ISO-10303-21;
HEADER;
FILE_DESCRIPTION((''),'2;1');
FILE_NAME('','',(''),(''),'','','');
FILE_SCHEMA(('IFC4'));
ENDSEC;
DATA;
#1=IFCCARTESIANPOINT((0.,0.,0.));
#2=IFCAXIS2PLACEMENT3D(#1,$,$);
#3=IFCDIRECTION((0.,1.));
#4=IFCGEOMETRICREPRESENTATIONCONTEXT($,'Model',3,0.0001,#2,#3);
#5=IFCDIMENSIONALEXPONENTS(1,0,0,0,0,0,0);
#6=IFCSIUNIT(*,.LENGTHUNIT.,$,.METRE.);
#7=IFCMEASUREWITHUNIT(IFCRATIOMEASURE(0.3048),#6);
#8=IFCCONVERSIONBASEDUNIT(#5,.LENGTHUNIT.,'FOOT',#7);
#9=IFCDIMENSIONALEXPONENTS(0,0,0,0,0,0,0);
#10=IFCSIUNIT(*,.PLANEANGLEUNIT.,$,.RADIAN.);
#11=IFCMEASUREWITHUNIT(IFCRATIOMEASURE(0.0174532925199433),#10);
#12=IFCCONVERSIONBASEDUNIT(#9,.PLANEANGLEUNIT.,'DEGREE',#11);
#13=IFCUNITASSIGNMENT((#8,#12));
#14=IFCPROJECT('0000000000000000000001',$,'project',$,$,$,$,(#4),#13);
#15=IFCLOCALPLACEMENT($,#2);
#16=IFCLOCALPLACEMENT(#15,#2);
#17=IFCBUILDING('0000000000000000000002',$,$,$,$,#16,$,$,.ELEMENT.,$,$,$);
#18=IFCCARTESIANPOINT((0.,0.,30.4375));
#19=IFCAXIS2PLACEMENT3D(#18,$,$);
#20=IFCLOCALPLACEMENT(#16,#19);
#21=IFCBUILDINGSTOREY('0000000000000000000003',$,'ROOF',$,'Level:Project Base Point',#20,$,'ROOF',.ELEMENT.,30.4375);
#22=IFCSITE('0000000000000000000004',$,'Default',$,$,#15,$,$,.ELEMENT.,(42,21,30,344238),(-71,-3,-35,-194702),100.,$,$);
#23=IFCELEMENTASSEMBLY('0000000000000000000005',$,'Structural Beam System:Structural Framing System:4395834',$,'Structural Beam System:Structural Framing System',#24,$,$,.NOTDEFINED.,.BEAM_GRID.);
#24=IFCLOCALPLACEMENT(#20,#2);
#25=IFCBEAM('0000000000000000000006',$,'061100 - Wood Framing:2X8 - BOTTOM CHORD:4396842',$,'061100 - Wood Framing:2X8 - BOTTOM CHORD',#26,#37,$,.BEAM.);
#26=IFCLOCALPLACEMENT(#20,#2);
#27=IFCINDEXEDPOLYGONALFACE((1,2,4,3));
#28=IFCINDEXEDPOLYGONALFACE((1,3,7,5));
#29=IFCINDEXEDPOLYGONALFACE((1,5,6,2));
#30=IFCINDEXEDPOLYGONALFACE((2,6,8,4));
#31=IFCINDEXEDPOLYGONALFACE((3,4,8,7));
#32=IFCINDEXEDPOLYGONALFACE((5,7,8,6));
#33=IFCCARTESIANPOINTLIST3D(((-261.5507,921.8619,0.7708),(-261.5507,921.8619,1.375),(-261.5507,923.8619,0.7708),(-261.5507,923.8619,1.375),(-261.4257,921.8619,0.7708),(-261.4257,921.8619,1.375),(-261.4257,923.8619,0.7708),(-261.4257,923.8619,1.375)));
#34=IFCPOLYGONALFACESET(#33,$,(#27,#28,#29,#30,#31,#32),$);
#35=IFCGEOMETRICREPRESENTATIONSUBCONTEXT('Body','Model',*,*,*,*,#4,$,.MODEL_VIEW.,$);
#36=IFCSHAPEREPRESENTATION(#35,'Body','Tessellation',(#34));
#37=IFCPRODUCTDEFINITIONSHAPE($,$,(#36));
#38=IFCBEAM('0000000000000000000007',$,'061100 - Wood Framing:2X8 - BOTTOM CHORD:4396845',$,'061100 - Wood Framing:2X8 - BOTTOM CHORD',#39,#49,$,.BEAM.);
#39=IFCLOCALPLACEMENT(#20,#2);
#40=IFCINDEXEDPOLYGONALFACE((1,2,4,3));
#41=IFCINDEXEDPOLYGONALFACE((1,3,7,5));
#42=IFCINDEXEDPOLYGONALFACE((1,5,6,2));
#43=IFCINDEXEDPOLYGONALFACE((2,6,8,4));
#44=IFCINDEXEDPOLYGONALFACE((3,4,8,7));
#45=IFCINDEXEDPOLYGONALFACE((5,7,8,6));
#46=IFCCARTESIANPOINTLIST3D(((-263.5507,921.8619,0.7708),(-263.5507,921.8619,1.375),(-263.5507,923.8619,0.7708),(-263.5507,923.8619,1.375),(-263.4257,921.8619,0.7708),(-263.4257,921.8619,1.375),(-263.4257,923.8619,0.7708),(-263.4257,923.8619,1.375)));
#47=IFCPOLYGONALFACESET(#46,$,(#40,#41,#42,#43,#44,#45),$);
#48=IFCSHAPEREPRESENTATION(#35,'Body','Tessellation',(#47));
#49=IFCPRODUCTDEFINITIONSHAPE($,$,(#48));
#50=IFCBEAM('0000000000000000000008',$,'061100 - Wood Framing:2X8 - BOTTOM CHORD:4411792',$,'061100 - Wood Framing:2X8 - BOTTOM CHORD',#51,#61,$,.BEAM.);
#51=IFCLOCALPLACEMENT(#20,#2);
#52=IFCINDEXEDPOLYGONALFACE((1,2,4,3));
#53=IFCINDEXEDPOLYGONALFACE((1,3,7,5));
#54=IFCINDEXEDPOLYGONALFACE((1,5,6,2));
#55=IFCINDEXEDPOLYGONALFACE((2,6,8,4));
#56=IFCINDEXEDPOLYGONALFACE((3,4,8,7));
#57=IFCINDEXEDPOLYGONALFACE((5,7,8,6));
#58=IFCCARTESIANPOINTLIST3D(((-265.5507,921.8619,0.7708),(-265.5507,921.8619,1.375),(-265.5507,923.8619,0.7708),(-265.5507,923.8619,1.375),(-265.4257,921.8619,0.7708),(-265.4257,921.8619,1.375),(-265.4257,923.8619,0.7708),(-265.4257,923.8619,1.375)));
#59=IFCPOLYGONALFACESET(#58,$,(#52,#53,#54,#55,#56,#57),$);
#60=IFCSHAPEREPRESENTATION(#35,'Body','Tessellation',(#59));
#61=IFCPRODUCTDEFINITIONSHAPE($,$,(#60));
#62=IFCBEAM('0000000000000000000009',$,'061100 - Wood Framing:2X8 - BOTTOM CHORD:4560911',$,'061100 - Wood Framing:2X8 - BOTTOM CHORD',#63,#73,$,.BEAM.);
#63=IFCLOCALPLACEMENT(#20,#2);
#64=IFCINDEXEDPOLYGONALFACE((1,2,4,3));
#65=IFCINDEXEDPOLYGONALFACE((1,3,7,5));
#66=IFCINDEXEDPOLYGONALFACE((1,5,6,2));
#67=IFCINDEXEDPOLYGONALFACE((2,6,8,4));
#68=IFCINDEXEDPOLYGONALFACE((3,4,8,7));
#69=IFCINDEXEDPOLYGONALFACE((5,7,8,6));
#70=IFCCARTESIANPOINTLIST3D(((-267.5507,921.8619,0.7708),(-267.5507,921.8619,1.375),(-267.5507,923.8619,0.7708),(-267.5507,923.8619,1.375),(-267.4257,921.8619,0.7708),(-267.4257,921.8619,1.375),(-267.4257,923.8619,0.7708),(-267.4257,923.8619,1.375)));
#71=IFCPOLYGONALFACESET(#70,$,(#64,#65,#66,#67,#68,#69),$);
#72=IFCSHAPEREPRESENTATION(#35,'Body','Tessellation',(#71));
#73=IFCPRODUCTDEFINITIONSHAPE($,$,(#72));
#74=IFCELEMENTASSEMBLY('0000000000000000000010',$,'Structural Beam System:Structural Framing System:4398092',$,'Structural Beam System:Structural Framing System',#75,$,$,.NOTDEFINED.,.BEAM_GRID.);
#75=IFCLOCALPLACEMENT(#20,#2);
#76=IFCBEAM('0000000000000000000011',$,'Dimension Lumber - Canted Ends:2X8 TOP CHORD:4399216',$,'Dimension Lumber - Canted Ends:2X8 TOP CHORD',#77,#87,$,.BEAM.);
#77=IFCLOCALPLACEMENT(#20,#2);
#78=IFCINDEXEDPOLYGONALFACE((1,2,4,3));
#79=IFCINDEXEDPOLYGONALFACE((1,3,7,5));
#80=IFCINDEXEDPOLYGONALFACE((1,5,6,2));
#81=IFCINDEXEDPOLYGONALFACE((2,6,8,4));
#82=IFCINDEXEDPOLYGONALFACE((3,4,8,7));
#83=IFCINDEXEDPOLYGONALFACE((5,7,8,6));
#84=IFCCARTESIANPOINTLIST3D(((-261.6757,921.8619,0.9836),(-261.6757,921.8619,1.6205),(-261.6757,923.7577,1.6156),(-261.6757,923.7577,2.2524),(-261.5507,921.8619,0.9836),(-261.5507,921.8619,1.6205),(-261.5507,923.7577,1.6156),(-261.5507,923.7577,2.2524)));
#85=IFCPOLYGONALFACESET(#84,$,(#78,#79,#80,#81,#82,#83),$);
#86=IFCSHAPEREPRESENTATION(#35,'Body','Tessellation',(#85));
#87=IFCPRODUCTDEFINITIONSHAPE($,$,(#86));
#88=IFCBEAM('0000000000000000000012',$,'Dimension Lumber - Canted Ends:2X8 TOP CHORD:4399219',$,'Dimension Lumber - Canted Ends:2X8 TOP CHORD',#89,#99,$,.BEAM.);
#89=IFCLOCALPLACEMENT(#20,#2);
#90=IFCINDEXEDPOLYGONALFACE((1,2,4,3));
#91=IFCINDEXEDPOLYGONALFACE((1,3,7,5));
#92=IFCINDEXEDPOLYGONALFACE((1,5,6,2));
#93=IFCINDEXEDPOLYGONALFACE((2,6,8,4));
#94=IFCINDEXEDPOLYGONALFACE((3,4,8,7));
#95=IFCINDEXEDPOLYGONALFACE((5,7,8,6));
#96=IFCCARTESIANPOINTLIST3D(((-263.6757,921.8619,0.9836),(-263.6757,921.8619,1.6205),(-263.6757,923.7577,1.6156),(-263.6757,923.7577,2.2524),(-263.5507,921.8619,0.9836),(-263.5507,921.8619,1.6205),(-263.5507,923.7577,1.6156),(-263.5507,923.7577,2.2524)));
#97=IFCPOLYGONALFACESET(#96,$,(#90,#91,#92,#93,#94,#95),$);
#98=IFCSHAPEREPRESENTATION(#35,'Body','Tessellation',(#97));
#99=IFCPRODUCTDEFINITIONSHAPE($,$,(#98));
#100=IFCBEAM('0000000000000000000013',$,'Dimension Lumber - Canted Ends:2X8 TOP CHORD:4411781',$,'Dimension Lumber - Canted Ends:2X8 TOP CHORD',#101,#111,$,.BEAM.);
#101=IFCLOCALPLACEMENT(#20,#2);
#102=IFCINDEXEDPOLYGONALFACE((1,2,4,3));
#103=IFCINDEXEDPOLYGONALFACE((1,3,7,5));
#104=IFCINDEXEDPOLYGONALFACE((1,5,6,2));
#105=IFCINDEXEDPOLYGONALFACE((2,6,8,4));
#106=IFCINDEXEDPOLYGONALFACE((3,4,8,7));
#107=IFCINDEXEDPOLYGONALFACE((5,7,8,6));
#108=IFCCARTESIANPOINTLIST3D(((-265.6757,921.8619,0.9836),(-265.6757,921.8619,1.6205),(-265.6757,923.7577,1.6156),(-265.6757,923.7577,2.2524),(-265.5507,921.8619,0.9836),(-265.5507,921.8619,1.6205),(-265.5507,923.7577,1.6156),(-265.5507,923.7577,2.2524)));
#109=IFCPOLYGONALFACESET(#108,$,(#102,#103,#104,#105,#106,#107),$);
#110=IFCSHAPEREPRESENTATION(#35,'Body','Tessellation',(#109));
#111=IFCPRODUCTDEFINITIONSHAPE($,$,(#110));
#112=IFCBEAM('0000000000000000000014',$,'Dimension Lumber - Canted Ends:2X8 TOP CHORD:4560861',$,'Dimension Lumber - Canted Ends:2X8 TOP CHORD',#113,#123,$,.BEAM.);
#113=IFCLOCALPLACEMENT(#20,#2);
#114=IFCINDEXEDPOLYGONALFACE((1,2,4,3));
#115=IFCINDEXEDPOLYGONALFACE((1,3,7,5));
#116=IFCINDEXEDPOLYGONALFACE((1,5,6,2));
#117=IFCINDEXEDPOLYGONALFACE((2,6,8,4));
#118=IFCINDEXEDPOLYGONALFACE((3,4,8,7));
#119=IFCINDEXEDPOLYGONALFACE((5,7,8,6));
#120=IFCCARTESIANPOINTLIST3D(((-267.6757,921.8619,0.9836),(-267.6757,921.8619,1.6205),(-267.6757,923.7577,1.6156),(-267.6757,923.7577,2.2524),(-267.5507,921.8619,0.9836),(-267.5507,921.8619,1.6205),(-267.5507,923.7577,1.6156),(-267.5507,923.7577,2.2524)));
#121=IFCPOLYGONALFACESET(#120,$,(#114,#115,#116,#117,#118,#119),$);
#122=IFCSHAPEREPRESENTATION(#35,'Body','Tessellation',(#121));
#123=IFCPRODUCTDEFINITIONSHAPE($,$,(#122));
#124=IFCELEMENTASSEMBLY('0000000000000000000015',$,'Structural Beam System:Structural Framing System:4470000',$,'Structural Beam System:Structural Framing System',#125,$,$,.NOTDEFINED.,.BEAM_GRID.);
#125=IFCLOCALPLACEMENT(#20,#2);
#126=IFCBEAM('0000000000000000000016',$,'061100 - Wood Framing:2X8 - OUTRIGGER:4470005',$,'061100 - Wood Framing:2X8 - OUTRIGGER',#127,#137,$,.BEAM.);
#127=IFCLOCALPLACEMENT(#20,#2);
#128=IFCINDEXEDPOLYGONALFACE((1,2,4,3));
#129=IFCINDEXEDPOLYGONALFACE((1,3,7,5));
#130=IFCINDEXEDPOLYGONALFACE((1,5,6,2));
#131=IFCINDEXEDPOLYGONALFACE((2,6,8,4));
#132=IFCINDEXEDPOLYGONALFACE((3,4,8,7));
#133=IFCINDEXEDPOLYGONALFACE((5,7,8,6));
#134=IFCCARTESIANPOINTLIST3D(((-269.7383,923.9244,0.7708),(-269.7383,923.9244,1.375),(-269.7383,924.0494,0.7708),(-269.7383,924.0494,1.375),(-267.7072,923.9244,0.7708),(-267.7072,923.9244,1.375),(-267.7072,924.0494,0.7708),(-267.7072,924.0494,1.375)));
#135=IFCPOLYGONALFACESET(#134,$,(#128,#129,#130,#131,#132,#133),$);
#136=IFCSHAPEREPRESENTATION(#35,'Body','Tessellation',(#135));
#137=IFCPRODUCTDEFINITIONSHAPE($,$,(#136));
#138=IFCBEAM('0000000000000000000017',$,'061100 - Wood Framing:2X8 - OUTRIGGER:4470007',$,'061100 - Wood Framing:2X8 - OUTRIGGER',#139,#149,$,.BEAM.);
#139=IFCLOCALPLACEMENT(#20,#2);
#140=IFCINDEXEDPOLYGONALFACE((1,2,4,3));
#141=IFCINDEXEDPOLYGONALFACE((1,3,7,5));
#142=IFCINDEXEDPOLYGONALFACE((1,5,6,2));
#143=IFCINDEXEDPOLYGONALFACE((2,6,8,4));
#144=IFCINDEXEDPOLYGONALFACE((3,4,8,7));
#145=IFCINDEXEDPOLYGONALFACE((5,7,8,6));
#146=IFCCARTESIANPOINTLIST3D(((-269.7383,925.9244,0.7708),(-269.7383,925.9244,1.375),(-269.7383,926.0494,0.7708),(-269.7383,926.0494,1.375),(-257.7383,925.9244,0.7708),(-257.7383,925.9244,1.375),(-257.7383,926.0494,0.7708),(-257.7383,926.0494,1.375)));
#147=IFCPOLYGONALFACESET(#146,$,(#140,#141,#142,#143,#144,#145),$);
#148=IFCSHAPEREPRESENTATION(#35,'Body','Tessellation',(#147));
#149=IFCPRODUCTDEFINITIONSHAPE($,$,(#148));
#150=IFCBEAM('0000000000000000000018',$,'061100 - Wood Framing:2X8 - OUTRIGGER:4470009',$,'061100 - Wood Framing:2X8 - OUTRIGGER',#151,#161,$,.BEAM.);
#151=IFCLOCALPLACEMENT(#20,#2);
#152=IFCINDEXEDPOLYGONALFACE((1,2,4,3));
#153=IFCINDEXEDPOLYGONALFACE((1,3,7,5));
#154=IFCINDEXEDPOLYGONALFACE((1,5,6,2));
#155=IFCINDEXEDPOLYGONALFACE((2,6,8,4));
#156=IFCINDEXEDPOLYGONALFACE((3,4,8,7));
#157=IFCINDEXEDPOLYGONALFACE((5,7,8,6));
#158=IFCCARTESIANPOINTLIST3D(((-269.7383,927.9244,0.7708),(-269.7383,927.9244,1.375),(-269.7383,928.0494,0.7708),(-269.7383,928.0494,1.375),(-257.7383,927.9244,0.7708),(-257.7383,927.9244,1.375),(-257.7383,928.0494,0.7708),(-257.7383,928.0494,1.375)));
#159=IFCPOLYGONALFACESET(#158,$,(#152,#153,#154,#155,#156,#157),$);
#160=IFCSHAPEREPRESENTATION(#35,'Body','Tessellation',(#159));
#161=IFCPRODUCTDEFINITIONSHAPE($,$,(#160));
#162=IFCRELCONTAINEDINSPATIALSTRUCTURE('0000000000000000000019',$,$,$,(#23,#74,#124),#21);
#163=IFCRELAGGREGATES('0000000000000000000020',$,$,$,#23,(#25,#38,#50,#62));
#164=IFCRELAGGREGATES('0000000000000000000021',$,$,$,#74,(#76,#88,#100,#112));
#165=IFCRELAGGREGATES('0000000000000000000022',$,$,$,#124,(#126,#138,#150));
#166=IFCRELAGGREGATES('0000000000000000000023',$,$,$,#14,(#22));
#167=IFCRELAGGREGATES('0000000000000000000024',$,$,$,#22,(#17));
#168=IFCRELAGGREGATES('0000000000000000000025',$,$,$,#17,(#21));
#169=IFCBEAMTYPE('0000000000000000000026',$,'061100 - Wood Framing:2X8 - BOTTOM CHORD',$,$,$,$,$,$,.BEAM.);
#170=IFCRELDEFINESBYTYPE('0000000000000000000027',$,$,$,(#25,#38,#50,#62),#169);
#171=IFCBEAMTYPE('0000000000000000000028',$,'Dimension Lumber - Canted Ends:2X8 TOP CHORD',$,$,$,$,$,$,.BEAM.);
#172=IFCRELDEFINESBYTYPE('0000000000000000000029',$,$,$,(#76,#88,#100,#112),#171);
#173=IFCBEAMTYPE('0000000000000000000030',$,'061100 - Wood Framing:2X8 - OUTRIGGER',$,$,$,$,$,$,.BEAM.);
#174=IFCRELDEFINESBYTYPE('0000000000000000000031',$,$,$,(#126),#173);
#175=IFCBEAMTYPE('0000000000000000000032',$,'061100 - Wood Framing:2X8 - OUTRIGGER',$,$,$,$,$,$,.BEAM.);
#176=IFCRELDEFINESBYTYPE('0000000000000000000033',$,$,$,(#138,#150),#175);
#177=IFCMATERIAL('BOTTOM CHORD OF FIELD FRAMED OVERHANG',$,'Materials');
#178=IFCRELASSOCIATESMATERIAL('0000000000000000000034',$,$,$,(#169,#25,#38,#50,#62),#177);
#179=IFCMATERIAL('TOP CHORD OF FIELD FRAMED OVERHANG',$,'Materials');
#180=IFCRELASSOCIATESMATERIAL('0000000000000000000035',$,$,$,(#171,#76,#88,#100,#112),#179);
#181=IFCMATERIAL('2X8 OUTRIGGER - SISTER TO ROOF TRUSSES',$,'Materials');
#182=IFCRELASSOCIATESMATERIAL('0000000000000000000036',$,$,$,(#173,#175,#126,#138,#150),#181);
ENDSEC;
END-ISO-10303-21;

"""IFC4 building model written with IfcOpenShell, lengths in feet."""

from ifc_helpers import new_model, entity, si_unit, converted_unit, direction, frame, origin, origin_2d_with_axis, place, context, subcontext, project, spatial, rectangle, extrude, clip, halfspace, source, transform, mapped, material, material_profile, profile_set, profile_usage, type_object, type_shapes, element, aggregate, save


model = new_model("IFC4")

# Units and contexts
model_context = context("Model", 3, precision=0.0001, world=origin(), true_north=direction((0.0, 1.0)))
body_context = subcontext(model_context, "Body", "Model", "MODEL_VIEW")
ifc_project = project(units=[converted_unit("LENGTHUNIT", "FOOT", entity("IfcRatioMeasure", 0.3048), si_unit("LENGTHUNIT", "METRE"), dimensions=[1, 0, 0, 0, 0, 0, 0]), converted_unit("PLANEANGLEUNIT", "DEGREE", entity("IfcRatioMeasure", 0.0174532925199433), si_unit("PLANEANGLEUNIT", "RADIAN"), dimensions=[0, 0, 0, 0, 0, 0, 0])], contexts=[model_context])

# Site, building, storey
site_placement = place(None, origin())
site = spatial("IfcSite", under=ifc_project, at=site_placement, Name="Default", CompositionType="ELEMENT", RefLatitude=(42, 21, 30, 344238), RefLongitude=(-71, -3, -35, -194702), RefElevation=100.0)
building_placement = place(site_placement, origin())
building = spatial("IfcBuilding", under=site, at=building_placement, CompositionType="ELEMENT")
storey_placement = place(building_placement, frame((0.0, 0.0, 30.4375)))
storey = spatial("IfcBuildingStorey", under=building, at=storey_placement, Name="ROOF", ObjectType="Level:Project Base Point", LongName="ROOF", CompositionType="ELEMENT", Elevation=30.4375)

# Element assemblies, beams
assembly_1_placement = place(storey_placement, origin())
assembly_1 = element("IfcElementAssembly", 1, at=assembly_1_placement, inside=storey, Name="Structural Beam System:Structural Framing System:4395834", ObjectType="Structural Beam System:Structural Framing System", AssemblyPlace="NOTDEFINED", PredefinedType="BEAM_GRID")
ifc_material_1 = material(Name="BOTTOM CHORD OF FIELD FRAMED OVERHANG", Category="Materials")
ifc_material_profile_1 = material_profile(ifc_material_1, rectangle(XDim=0.6042, YDim=0.125, at=origin_2d_with_axis()), Name="2X8 - BOTTOM CHORD")
ifc_profile_set_1 = profile_set([ifc_material_profile_1], Name="2X8 - BOTTOM CHORD")
ifc_profile_usage_1 = profile_usage(ifc_profile_set_1, cardinal=8)
beam_type_1 = type_object("IfcBeamType", Name="061100 - Wood Framing:2X8 - BOTTOM CHORD", PredefinedType="BEAM", material=ifc_profile_set_1)
shared_shape_1 = source(origin(), body_context, "Body", "SweptSolid", [
    extrude(rectangle(XDim=0.6042, YDim=0.125, at=origin_2d_with_axis()), frame((-1.0, 0.0, 0.0), z_axis=(1.0, 0.0, 0.0), x_axis=(0.0, 0.0, -1.0)), (0.0, 0.0, 1.0), 2.0),
])
type_shapes(beam_type_1, [shared_shape_1])
beam_1_placement = place(assembly_1_placement, frame((-261.4882, 922.8619, 1.0729), z_axis=(0.0, 0.0, 1.0), x_axis=(0.0, -1.0, 0.0)))
beam_1 = element("IfcBeam", 2, at=beam_1_placement, type_object=beam_type_1, material=ifc_profile_usage_1, Name="061100 - Wood Framing:2X8 - BOTTOM CHORD:4396842", ObjectType="061100 - Wood Framing:2X8 - BOTTOM CHORD", PredefinedType="BEAM", context=body_context, shape_type="MappedRepresentation", body=[
    mapped(shared_shape_1, transform((0.0, 0.0, 0.0), scale=1.0)),
])
ifc_profile_usage_2 = profile_usage(ifc_profile_set_1, cardinal=8)
beam_2_placement = place(assembly_1_placement, frame((-263.4882, 922.8619, 1.0729), z_axis=(0.0, 0.0, 1.0), x_axis=(0.0, -1.0, 0.0)))
beam_2 = element("IfcBeam", 3, at=beam_2_placement, type_object=beam_type_1, material=ifc_profile_usage_2, Name="061100 - Wood Framing:2X8 - BOTTOM CHORD:4396845", ObjectType="061100 - Wood Framing:2X8 - BOTTOM CHORD", PredefinedType="BEAM", context=body_context, shape_type="MappedRepresentation", body=[
    mapped(shared_shape_1, transform((0.0, 0.0, 0.0), scale=1.0)),
])
ifc_profile_usage_3 = profile_usage(ifc_profile_set_1, cardinal=8)
beam_3_placement = place(assembly_1_placement, frame((-265.4882, 922.8619, 1.0729), z_axis=(0.0, 0.0, 1.0), x_axis=(0.0, -1.0, 0.0)))
beam_3 = element("IfcBeam", 4, at=beam_3_placement, type_object=beam_type_1, material=ifc_profile_usage_3, Name="061100 - Wood Framing:2X8 - BOTTOM CHORD:4411792", ObjectType="061100 - Wood Framing:2X8 - BOTTOM CHORD", PredefinedType="BEAM", context=body_context, shape_type="MappedRepresentation", body=[
    mapped(shared_shape_1, transform((0.0, 0.0, 0.0), scale=1.0)),
])
ifc_profile_usage_4 = profile_usage(ifc_profile_set_1, cardinal=8)
beam_4_placement = place(assembly_1_placement, frame((-267.4882, 922.8619, 1.0729), z_axis=(0.0, 0.0, 1.0), x_axis=(0.0, -1.0, 0.0)))
beam_4 = element("IfcBeam", 5, at=beam_4_placement, type_object=beam_type_1, material=ifc_profile_usage_4, Name="061100 - Wood Framing:2X8 - BOTTOM CHORD:4560911", ObjectType="061100 - Wood Framing:2X8 - BOTTOM CHORD", PredefinedType="BEAM", context=body_context, shape_type="MappedRepresentation", body=[
    mapped(shared_shape_1, transform((0.0, 0.0, 0.0), scale=1.0)),
])
aggregate(assembly_1, [beam_1, beam_2, beam_3, beam_4])
assembly_2_placement = place(storey_placement, origin())
assembly_2 = element("IfcElementAssembly", 6, at=assembly_2_placement, inside=storey, Name="Structural Beam System:Structural Framing System:4398092", ObjectType="Structural Beam System:Structural Framing System", AssemblyPlace="NOTDEFINED", PredefinedType="BEAM_GRID")
ifc_material_2 = material(Name="TOP CHORD OF FIELD FRAMED OVERHANG", Category="Materials")
ifc_material_profile_2 = material_profile(ifc_material_2, rectangle(XDim=0.6042, YDim=0.125, at=origin_2d_with_axis()), Name="2X8 TOP CHORD")
ifc_profile_set_2 = profile_set([ifc_material_profile_2], Name="2X8 TOP CHORD")
ifc_profile_usage_5 = profile_usage(ifc_profile_set_2, cardinal=8)
beam_type_2 = type_object("IfcBeamType", Name="Dimension Lumber - Canted Ends:2X8 TOP CHORD", PredefinedType="BEAM", material=ifc_profile_set_2)
shared_shape_2 = source(origin(), body_context, "Body", "Clipping", [
    clip(clip(extrude(rectangle(XDim=0.6042, YDim=0.125, at=origin_2d_with_axis()), frame((-0.9992, 0.0, 0.0), z_axis=(1.0, 0.0, 0.0), x_axis=(0.0, 0.0, -1.0)), (0.0, 0.0, 1.0), 2.1997), halfspace(frame((0.9992, -0.0625, -0.3021), z_axis=(0.948711, 0.0, -0.316146), x_axis=(0.0, 1.0, 0.0)), False)), halfspace(frame((-0.7979, -0.0625, 0.3021), z_axis=(-0.948711, 0.0, 0.316146), x_axis=(0.0, 1.0, 0.0)), False)),
])
type_shapes(beam_type_2, [shared_shape_2])
beam_5_placement = place(assembly_2_placement, frame((-261.6132, 922.7143, 1.5862), z_axis=(0.0, -0.316228, 0.948683), x_axis=(0.0, 0.948683, 0.316228)))
beam_5 = element("IfcBeam", 7, at=beam_5_placement, type_object=beam_type_2, material=ifc_profile_usage_5, Name="Dimension Lumber - Canted Ends:2X8 TOP CHORD:4399216", ObjectType="Dimension Lumber - Canted Ends:2X8 TOP CHORD", PredefinedType="BEAM", context=body_context, shape_type="MappedRepresentation", body=[
    mapped(shared_shape_2, transform((0.0, 0.0, 0.0), scale=1.0)),
])
ifc_profile_usage_6 = profile_usage(ifc_profile_set_2, cardinal=8)
beam_6_placement = place(assembly_2_placement, frame((-263.6132, 922.7143, 1.5862), z_axis=(0.0, -0.316228, 0.948683), x_axis=(0.0, 0.948683, 0.316228)))
beam_6 = element("IfcBeam", 8, at=beam_6_placement, type_object=beam_type_2, material=ifc_profile_usage_6, Name="Dimension Lumber - Canted Ends:2X8 TOP CHORD:4399219", ObjectType="Dimension Lumber - Canted Ends:2X8 TOP CHORD", PredefinedType="BEAM", context=body_context, shape_type="MappedRepresentation", body=[
    mapped(shared_shape_2, transform((0.0, 0.0, 0.0), scale=1.0)),
])
ifc_profile_usage_7 = profile_usage(ifc_profile_set_2, cardinal=8)
beam_7_placement = place(assembly_2_placement, frame((-265.6132, 922.7143, 1.5862), z_axis=(0.0, -0.316228, 0.948683), x_axis=(0.0, 0.948683, 0.316228)))
beam_7 = element("IfcBeam", 9, at=beam_7_placement, type_object=beam_type_2, material=ifc_profile_usage_7, Name="Dimension Lumber - Canted Ends:2X8 TOP CHORD:4411781", ObjectType="Dimension Lumber - Canted Ends:2X8 TOP CHORD", PredefinedType="BEAM", context=body_context, shape_type="MappedRepresentation", body=[
    mapped(shared_shape_2, transform((0.0, 0.0, 0.0), scale=1.0)),
])
ifc_profile_usage_8 = profile_usage(ifc_profile_set_2, cardinal=8)
beam_8_placement = place(assembly_2_placement, frame((-267.6132, 922.7143, 1.5862), z_axis=(0.0, -0.316228, 0.948683), x_axis=(0.0, 0.948683, 0.316228)))
beam_8 = element("IfcBeam", 10, at=beam_8_placement, type_object=beam_type_2, material=ifc_profile_usage_8, Name="Dimension Lumber - Canted Ends:2X8 TOP CHORD:4560861", ObjectType="Dimension Lumber - Canted Ends:2X8 TOP CHORD", PredefinedType="BEAM", context=body_context, shape_type="MappedRepresentation", body=[
    mapped(shared_shape_2, transform((0.0, 0.0, 0.0), scale=1.0)),
])
aggregate(assembly_2, [beam_5, beam_6, beam_7, beam_8])
assembly_3_placement = place(storey_placement, origin())
assembly_3 = element("IfcElementAssembly", 11, at=assembly_3_placement, inside=storey, Name="Structural Beam System:Structural Framing System:4470000", ObjectType="Structural Beam System:Structural Framing System", AssemblyPlace="NOTDEFINED", PredefinedType="BEAM_GRID")
ifc_material_3 = material(Name="2X8 OUTRIGGER - SISTER TO ROOF TRUSSES", Category="Materials")
ifc_material_profile_3 = material_profile(ifc_material_3, rectangle(XDim=0.6042, YDim=0.125, at=origin_2d_with_axis()), Name="2X8 - OUTRIGGER")
ifc_profile_set_3 = profile_set([ifc_material_profile_3], Name="2X8 - OUTRIGGER")
ifc_profile_usage_9 = profile_usage(ifc_profile_set_3, cardinal=8)
beam_type_3 = type_object("IfcBeamType", Name="061100 - Wood Framing:2X8 - OUTRIGGER", PredefinedType="BEAM", material=ifc_profile_set_3)
shared_shape_3 = source(origin(), body_context, "Body", "SweptSolid", [
    extrude(rectangle(XDim=0.6042, YDim=0.125, at=origin_2d_with_axis()), frame((-0.941, 0.0, 0.0), z_axis=(1.0, 0.0, 0.0), x_axis=(0.0, 0.0, -1.0)), (0.0, 0.0, 1.0), 2.0311),
])
type_shapes(beam_type_3, [shared_shape_3])
beam_9_placement = place(assembly_3_placement, frame((-268.6482, 923.9869, 1.0729), z_axis=(0.0, 0.0, 1.0), x_axis=(-1.0, 0.0, 0.0)))
beam_9 = element("IfcBeam", 12, at=beam_9_placement, type_object=beam_type_3, material=ifc_profile_usage_9, Name="061100 - Wood Framing:2X8 - OUTRIGGER:4470005", ObjectType="061100 - Wood Framing:2X8 - OUTRIGGER", PredefinedType="BEAM", context=body_context, shape_type="MappedRepresentation", body=[
    mapped(shared_shape_3, transform((0.0, 0.0, 0.0), scale=1.0)),
])
ifc_profile_usage_10 = profile_usage(ifc_profile_set_3, cardinal=8)
beam_type_4 = type_object("IfcBeamType", Name="061100 - Wood Framing:2X8 - OUTRIGGER", PredefinedType="BEAM", material=ifc_profile_set_3)
shared_shape_4 = source(origin(), body_context, "Body", "SweptSolid", [
    extrude(rectangle(XDim=0.6042, YDim=0.125, at=origin_2d_with_axis()), frame((-6.0, 0.0, 0.0), z_axis=(1.0, 0.0, 0.0), x_axis=(0.0, 0.0, -1.0)), (0.0, 0.0, 1.0), 12.0),
])
type_shapes(beam_type_4, [shared_shape_4])
beam_10_placement = place(assembly_3_placement, frame((-263.7383, 925.9869, 1.0729), z_axis=(0.0, 0.0, 1.0), x_axis=(-1.0, 0.0, 0.0)))
beam_10 = element("IfcBeam", 13, at=beam_10_placement, type_object=beam_type_4, material=ifc_profile_usage_10, Name="061100 - Wood Framing:2X8 - OUTRIGGER:4470007", ObjectType="061100 - Wood Framing:2X8 - OUTRIGGER", PredefinedType="BEAM", context=body_context, shape_type="MappedRepresentation", body=[
    mapped(shared_shape_4, transform((0.0, 0.0, 0.0), scale=1.0)),
])
ifc_profile_usage_11 = profile_usage(ifc_profile_set_3, cardinal=8)
beam_11_placement = place(assembly_3_placement, frame((-263.7383, 927.9869, 1.0729), z_axis=(0.0, 0.0, 1.0), x_axis=(-1.0, 0.0, 0.0)))
beam_11 = element("IfcBeam", 14, at=beam_11_placement, type_object=beam_type_4, material=ifc_profile_usage_11, Name="061100 - Wood Framing:2X8 - OUTRIGGER:4470009", ObjectType="061100 - Wood Framing:2X8 - OUTRIGGER", PredefinedType="BEAM", context=body_context, shape_type="MappedRepresentation", body=[
    mapped(shared_shape_4, transform((0.0, 0.0, 0.0), scale=1.0)),
])
aggregate(assembly_3, [beam_9, beam_10, beam_11])

save(model, "model.ifc")
